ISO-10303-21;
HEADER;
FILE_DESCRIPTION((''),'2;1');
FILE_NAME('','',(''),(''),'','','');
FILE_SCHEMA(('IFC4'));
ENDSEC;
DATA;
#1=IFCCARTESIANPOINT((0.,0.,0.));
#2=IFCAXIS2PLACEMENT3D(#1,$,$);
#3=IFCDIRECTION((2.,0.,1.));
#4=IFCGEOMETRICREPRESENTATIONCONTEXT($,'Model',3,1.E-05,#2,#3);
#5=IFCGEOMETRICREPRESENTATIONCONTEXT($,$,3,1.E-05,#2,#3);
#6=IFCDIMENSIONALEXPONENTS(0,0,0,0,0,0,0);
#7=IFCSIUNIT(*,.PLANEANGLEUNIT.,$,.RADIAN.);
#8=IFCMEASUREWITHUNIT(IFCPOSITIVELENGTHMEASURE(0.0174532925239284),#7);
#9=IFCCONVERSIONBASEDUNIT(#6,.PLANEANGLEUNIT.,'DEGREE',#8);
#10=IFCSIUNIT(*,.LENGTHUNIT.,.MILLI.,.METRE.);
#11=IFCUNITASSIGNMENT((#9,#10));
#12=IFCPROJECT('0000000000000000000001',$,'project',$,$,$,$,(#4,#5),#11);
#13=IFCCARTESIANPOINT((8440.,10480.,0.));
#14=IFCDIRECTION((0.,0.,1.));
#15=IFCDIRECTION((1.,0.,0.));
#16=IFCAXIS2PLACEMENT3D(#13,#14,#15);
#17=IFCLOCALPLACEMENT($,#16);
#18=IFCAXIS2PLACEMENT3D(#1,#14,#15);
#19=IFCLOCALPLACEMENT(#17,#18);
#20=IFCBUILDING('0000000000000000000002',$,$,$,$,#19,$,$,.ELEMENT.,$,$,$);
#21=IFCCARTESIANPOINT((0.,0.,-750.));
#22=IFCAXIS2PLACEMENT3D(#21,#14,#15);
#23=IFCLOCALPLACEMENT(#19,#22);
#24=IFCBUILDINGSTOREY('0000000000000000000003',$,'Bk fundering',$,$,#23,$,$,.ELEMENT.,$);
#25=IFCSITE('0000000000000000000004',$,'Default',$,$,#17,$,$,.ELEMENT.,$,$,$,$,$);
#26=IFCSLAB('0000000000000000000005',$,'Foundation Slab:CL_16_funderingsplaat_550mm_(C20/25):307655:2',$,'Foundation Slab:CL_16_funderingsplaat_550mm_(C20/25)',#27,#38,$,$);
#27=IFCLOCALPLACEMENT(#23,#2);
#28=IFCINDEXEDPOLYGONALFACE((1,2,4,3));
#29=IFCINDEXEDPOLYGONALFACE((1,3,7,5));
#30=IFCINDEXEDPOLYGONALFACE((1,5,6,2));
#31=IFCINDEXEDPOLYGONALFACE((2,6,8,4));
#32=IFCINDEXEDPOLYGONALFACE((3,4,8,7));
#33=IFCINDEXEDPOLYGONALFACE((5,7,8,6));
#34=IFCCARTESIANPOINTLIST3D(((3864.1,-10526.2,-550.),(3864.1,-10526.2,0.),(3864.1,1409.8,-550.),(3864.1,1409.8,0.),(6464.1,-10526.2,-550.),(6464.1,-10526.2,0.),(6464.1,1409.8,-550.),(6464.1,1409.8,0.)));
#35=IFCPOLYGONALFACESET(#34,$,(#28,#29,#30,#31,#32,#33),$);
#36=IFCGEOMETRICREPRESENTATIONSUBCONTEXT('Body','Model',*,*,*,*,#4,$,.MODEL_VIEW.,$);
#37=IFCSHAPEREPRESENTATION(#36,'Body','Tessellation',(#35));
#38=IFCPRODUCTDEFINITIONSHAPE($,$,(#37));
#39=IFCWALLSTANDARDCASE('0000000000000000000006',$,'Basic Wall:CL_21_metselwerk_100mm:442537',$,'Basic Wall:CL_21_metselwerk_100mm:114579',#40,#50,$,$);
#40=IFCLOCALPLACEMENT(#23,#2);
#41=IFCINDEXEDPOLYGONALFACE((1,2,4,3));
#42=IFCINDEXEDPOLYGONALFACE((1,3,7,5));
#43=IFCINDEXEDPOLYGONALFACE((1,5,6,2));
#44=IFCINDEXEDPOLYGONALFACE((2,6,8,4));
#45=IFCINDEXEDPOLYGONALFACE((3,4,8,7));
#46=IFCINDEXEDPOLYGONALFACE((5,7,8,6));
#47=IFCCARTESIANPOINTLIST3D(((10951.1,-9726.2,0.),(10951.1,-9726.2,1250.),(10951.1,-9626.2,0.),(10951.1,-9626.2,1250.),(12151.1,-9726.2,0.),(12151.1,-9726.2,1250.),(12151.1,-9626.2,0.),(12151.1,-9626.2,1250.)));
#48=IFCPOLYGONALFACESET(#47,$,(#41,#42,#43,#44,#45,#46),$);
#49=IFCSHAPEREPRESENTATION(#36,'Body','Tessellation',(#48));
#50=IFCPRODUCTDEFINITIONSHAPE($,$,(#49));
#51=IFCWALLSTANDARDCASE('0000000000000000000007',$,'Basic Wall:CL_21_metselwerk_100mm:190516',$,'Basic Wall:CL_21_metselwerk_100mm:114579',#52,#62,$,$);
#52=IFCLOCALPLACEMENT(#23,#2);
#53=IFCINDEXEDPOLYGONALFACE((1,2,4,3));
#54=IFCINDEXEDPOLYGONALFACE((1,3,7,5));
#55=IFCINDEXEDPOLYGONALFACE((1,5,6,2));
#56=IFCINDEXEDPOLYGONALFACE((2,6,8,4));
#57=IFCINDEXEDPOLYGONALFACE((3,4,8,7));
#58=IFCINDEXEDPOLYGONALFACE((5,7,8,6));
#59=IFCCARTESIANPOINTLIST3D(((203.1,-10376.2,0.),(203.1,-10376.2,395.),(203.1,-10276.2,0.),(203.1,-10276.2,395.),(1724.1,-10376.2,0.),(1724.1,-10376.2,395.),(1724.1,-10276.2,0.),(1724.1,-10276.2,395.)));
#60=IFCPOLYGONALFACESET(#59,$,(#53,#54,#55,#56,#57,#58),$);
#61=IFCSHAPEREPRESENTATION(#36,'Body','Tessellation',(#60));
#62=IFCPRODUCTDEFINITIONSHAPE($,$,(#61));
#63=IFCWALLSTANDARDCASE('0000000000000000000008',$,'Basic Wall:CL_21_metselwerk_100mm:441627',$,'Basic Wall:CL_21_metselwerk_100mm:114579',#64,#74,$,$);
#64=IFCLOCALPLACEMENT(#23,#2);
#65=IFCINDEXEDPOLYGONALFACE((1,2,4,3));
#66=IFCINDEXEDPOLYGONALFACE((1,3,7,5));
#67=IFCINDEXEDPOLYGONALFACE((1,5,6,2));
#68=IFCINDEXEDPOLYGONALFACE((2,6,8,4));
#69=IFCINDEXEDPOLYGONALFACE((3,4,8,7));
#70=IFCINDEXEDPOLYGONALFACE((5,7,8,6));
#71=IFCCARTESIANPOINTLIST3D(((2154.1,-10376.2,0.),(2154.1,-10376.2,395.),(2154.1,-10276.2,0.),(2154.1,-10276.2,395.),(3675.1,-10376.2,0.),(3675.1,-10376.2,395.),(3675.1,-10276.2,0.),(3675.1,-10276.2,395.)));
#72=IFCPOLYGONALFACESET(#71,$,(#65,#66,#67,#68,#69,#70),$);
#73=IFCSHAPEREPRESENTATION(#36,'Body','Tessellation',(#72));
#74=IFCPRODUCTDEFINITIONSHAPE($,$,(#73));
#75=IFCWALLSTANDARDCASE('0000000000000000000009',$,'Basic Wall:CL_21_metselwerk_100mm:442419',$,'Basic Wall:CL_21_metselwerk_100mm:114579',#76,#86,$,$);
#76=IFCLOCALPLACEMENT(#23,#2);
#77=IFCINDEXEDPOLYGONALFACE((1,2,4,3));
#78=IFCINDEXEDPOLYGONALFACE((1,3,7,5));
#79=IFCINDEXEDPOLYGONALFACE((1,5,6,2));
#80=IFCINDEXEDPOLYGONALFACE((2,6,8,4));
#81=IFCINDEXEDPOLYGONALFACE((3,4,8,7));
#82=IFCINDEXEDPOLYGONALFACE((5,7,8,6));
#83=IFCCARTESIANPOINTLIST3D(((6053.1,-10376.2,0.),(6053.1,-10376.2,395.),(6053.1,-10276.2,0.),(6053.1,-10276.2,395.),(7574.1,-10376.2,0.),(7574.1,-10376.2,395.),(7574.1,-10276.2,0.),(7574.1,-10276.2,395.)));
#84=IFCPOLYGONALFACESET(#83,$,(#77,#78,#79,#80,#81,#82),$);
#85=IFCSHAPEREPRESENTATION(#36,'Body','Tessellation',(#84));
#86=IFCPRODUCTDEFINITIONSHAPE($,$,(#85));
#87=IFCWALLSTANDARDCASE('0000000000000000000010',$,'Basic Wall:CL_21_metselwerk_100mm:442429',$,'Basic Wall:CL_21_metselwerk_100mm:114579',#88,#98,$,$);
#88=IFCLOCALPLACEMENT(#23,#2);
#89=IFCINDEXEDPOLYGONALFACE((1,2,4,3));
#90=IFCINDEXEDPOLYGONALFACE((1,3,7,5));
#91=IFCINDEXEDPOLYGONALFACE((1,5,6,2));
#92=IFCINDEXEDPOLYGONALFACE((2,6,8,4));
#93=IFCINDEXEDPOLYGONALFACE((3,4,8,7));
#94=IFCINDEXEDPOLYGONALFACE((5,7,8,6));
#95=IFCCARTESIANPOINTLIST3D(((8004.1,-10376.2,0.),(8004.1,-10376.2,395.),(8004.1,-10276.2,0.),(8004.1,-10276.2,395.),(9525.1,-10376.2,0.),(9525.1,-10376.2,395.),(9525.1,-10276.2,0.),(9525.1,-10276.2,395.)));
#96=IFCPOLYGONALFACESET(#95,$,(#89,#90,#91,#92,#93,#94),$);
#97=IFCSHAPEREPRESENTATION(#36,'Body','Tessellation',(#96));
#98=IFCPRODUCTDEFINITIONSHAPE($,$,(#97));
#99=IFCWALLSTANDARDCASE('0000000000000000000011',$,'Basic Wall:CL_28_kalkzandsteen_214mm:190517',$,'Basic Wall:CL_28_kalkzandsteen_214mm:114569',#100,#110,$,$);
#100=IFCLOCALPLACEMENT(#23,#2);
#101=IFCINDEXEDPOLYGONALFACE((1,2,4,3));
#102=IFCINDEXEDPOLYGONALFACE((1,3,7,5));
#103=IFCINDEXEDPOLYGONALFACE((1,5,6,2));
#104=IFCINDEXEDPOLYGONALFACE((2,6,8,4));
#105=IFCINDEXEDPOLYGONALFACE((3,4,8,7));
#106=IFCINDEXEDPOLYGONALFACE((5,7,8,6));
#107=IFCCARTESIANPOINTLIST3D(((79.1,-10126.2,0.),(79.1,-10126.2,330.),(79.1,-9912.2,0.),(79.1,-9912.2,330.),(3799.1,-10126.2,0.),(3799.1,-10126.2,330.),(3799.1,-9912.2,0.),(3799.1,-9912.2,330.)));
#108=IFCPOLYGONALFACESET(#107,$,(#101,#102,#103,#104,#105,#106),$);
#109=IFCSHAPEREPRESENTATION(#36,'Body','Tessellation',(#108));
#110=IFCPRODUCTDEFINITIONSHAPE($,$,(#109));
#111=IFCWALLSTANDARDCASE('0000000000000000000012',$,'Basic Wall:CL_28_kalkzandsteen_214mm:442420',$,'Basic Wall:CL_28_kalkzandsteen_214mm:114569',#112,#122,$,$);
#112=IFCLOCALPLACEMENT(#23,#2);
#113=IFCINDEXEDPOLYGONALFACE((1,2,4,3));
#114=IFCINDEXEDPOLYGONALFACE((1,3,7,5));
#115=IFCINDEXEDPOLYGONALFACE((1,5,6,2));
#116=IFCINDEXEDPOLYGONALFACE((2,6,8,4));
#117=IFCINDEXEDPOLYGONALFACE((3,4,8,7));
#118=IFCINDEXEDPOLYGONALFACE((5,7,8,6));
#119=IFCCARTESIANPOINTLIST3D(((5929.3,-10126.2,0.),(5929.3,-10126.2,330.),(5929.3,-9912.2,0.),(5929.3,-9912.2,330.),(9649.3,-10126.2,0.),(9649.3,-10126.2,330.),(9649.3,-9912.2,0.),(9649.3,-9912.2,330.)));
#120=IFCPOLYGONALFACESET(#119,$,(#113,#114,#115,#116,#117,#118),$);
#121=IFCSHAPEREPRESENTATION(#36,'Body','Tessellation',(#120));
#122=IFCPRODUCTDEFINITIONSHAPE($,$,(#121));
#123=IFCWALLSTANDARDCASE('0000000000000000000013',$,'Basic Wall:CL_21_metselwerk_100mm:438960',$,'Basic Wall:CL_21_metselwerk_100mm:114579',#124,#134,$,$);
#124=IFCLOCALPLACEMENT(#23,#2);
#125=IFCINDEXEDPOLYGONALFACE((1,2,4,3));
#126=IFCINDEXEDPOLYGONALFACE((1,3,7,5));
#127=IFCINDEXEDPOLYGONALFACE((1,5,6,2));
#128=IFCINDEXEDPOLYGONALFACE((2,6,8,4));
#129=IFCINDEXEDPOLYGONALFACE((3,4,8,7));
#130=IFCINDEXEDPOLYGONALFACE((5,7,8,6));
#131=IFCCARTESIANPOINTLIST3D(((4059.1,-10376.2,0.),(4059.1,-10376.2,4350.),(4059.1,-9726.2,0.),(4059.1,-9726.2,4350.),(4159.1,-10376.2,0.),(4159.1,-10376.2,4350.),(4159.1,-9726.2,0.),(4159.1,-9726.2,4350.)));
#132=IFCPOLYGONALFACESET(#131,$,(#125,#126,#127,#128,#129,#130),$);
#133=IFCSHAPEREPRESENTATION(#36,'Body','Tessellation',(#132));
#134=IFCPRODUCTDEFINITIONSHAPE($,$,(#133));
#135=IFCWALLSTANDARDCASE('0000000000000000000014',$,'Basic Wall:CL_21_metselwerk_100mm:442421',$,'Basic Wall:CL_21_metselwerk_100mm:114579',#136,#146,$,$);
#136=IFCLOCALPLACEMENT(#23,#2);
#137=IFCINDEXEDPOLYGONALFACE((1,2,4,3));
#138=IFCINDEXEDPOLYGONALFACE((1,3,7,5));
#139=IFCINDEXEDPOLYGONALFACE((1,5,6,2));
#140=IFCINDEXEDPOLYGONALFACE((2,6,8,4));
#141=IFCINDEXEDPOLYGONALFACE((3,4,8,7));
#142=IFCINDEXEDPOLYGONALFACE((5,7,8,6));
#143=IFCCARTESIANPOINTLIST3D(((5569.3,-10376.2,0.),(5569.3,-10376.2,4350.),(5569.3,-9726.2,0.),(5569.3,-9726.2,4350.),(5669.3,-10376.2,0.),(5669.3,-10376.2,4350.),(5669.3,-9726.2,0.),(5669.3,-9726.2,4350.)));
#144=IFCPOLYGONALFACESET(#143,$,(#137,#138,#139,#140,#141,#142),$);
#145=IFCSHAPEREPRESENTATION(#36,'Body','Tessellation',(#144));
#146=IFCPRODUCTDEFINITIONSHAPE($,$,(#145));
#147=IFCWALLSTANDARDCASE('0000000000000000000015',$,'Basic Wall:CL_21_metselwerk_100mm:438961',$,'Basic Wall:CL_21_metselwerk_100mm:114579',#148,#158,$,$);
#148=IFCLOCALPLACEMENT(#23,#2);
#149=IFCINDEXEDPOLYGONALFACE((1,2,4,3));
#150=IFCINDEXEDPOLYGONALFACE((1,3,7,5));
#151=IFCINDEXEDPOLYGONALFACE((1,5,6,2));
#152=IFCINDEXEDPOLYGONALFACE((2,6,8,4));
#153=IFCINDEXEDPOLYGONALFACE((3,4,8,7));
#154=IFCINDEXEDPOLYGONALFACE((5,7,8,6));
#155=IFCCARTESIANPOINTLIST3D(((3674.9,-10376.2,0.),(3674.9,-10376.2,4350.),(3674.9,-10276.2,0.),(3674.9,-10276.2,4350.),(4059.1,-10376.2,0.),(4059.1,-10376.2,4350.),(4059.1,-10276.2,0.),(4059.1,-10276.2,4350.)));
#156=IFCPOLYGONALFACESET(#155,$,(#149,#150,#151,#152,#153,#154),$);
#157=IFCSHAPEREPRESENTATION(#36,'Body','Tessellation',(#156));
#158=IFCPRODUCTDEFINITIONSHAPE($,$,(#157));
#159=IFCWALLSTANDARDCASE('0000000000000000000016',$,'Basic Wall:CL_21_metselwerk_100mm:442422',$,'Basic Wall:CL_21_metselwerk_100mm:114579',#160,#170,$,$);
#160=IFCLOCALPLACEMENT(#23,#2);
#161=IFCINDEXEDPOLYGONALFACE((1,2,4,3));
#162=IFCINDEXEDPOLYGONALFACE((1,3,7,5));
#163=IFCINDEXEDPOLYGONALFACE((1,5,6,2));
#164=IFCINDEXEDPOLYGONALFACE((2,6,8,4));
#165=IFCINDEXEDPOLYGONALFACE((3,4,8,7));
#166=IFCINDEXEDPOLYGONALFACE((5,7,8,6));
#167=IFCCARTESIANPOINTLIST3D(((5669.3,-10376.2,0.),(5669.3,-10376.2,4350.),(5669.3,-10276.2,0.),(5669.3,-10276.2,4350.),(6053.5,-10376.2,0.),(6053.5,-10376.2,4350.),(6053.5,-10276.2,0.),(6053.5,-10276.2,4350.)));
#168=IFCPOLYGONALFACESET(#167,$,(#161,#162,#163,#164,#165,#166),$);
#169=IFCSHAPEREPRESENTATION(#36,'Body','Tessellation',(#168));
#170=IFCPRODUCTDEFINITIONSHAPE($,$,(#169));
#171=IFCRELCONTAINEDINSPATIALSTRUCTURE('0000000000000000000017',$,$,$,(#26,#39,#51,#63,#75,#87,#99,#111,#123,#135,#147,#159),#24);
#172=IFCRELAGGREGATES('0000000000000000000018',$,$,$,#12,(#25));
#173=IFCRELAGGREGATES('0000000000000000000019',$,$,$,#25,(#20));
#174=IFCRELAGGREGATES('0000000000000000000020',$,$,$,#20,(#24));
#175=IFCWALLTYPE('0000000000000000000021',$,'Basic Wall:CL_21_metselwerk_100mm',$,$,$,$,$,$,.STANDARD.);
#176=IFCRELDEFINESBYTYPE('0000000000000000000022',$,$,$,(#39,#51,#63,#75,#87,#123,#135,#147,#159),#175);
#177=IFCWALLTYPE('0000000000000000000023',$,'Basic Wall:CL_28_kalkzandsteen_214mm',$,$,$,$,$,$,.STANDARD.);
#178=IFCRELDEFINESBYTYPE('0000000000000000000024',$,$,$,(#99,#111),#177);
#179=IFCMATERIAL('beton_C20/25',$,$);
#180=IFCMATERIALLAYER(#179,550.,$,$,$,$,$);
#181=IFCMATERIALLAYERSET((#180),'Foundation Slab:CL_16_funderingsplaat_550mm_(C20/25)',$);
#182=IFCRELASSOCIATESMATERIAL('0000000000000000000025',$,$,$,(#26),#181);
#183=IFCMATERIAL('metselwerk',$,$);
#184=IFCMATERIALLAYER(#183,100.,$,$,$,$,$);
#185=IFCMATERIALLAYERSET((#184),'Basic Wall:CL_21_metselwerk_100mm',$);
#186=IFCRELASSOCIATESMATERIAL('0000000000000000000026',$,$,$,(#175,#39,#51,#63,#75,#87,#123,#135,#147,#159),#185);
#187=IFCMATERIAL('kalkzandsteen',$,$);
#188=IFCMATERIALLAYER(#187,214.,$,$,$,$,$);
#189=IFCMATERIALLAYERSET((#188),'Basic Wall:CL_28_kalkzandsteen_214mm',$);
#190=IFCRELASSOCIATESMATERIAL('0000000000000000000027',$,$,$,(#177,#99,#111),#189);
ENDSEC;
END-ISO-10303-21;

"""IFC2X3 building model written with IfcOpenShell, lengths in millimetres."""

from ifc_helpers import new_model, entity, si_unit, converted_unit, direction, frame, frame_2d, origin, origin_with_axes, place, context, subcontext, project, spatial, rectangle, extrude, source, transform, mapped, material, layer, layer_set, layer_usage, type_object, element, save


model = new_model("IFC2X3")

# Units and contexts
model_context = context("Model", 3, precision=1e-05, world=origin(), true_north=direction((2.0, 0.0, 1.0)))
context_of_model = context(None, 3, precision=1e-05, world=origin(), true_north=direction((2.0, 0.0, 1.0)))
body_context = subcontext(model_context, "Body", "Model", "MODEL_VIEW")
ifc_project = project(units=[converted_unit("PLANEANGLEUNIT", "DEGREE", entity("IfcPositiveLengthMeasure", 0.0174532925239284), si_unit("PLANEANGLEUNIT", "RADIAN"), dimensions=[0, 0, 0, 0, 0, 0, 0]), si_unit("LENGTHUNIT", "METRE", prefix="MILLI")], contexts=[model_context, context_of_model])

# Site, building, storey
site_placement = place(None, frame((8440.0, 10480.0, 0.0), z_axis=(0.0, 0.0, 1.0), x_axis=(1.0, 0.0, 0.0)))
site = spatial("IfcSite", under=ifc_project, at=site_placement, Name="Default", CompositionType="ELEMENT")
building_placement = place(site_placement, origin_with_axes())
building = spatial("IfcBuilding", under=site, at=building_placement, CompositionType="ELEMENT")
storey_placement = place(building_placement, frame((0.0, 0.0, -750.0), z_axis=(0.0, 0.0, 1.0), x_axis=(1.0, 0.0, 0.0)))
storey = spatial("IfcBuildingStorey", under=building, at=storey_placement, Name="Bk fundering", CompositionType="ELEMENT")

# Slab
ifc_material_1 = material(Name="beton_C20/25")
ifc_layer_1 = layer(ifc_material_1, 550.0)
ifc_layer_set_1 = layer_set([ifc_layer_1], Name="Foundation Slab:CL_16_funderingsplaat_550mm_(C20/25)")
ifc_layer_usage_1 = layer_usage(ifc_layer_set_1, "AXIS3", "POSITIVE", 0.0)
slab_1_placement = place(storey_placement, frame((3864.1, -10526.2, -550.0), z_axis=(0.0, 0.0, 1.0), x_axis=(1.0, 0.0, 0.0)))
element("IfcSlab", 1, at=slab_1_placement, inside=storey, material=ifc_layer_usage_1, Name="Foundation Slab:CL_16_funderingsplaat_550mm_(C20/25):307655:2", ObjectType="Foundation Slab:CL_16_funderingsplaat_550mm_(C20/25)", context=body_context, shape_type="SweptSolid", body=[
    extrude(rectangle(XDim=2600.0, YDim=11936.0, at=frame_2d((0.0, -2075.0), x_axis=(1.0, 0.0))), frame((1300.0, 8043.0, 550.0), z_axis=(0.0, 0.0, -1.0), x_axis=(-1.0, 0.0, 0.0)), (0.0, 0.0, 1.0), 550.0),
])

# Walls
ifc_material_2 = material(Name="metselwerk")
ifc_layer_2 = layer(ifc_material_2, 100.0)
ifc_layer_set_2 = layer_set([ifc_layer_2], Name="Basic Wall:CL_21_metselwerk_100mm")
ifc_layer_usage_2 = layer_usage(ifc_layer_set_2, "AXIS2", "NEGATIVE", 50.0)
wall_type_1 = type_object("IfcWallType", Name="Basic Wall:CL_21_metselwerk_100mm", PredefinedType="STANDARD", material=ifc_layer_set_2)
shared_shape_1 = source(origin(), body_context, "Body", "SweptSolid", [
    extrude(rectangle(XDim=1200.0, YDim=100.0, at=frame_2d((600.0, 0.0), x_axis=(-1.0, 0.0))), origin(), (0.0, 0.0, 1.0), 1250.0),
])
wall_1_placement = place(storey_placement, frame((10951.1, -9676.2, 0.0), z_axis=(0.0, 0.0, 1.0), x_axis=(1.0, 0.0, 0.0)))
element("IfcWallStandardCase", 2, at=wall_1_placement, inside=storey, type_object=wall_type_1, material=ifc_layer_usage_2, Name="Basic Wall:CL_21_metselwerk_100mm:442537", ObjectType="Basic Wall:CL_21_metselwerk_100mm:114579", context=body_context, shape_type="MappedRepresentation", body=[
    mapped(shared_shape_1, transform((0.0, 0.0, 0.0))),
])
ifc_layer_usage_3 = layer_usage(ifc_layer_set_2, "AXIS2", "NEGATIVE", 50.0)
shared_shape_2 = source(origin(), body_context, "Body", "SweptSolid", [
    extrude(rectangle(XDim=1521.0, YDim=100.0, at=frame_2d((760.5, 0.0), x_axis=(-1.0, 0.0))), origin(), (0.0, 0.0, 1.0), 395.0),
])
wall_2_placement = place(storey_placement, frame((203.1, -10326.2, 0.0), z_axis=(0.0, 0.0, 1.0), x_axis=(1.0, 0.0, 0.0)))
element("IfcWallStandardCase", 3, at=wall_2_placement, inside=storey, type_object=wall_type_1, material=ifc_layer_usage_3, Name="Basic Wall:CL_21_metselwerk_100mm:190516", ObjectType="Basic Wall:CL_21_metselwerk_100mm:114579", context=body_context, shape_type="MappedRepresentation", body=[
    mapped(shared_shape_2, transform((0.0, 0.0, 0.0))),
])
ifc_layer_usage_4 = layer_usage(ifc_layer_set_2, "AXIS2", "NEGATIVE", 50.0)
wall_3_placement = place(storey_placement, frame((2154.1, -10326.2, 0.0), z_axis=(0.0, 0.0, 1.0), x_axis=(1.0, 0.0, 0.0)))
element("IfcWallStandardCase", 4, at=wall_3_placement, inside=storey, type_object=wall_type_1, material=ifc_layer_usage_4, Name="Basic Wall:CL_21_metselwerk_100mm:441627", ObjectType="Basic Wall:CL_21_metselwerk_100mm:114579", context=body_context, shape_type="MappedRepresentation", body=[
    mapped(shared_shape_2, transform((0.0, 0.0, 0.0))),
])
ifc_layer_usage_5 = layer_usage(ifc_layer_set_2, "AXIS2", "NEGATIVE", 50.0)
wall_4_placement = place(storey_placement, frame((6053.1, -10326.2, 0.0), z_axis=(0.0, 0.0, 1.0), x_axis=(1.0, 0.0, 0.0)))
element("IfcWallStandardCase", 5, at=wall_4_placement, inside=storey, type_object=wall_type_1, material=ifc_layer_usage_5, Name="Basic Wall:CL_21_metselwerk_100mm:442419", ObjectType="Basic Wall:CL_21_metselwerk_100mm:114579", context=body_context, shape_type="MappedRepresentation", body=[
    mapped(shared_shape_2, transform((0.0, 0.0, 0.0))),
])
ifc_layer_usage_6 = layer_usage(ifc_layer_set_2, "AXIS2", "NEGATIVE", 50.0)
wall_5_placement = place(storey_placement, frame((8004.1, -10326.2, 0.0), z_axis=(0.0, 0.0, 1.0), x_axis=(1.0, 0.0, 0.0)))
element("IfcWallStandardCase", 6, at=wall_5_placement, inside=storey, type_object=wall_type_1, material=ifc_layer_usage_6, Name="Basic Wall:CL_21_metselwerk_100mm:442429", ObjectType="Basic Wall:CL_21_metselwerk_100mm:114579", context=body_context, shape_type="MappedRepresentation", body=[
    mapped(shared_shape_2, transform((0.0, 0.0, 0.0))),
])
ifc_material_3 = material(Name="kalkzandsteen")
ifc_layer_3 = layer(ifc_material_3, 214.0)
ifc_layer_set_3 = layer_set([ifc_layer_3], Name="Basic Wall:CL_28_kalkzandsteen_214mm")
ifc_layer_usage_7 = layer_usage(ifc_layer_set_3, "AXIS2", "NEGATIVE", 107.0)
wall_type_2 = type_object("IfcWallType", Name="Basic Wall:CL_28_kalkzandsteen_214mm", PredefinedType="STANDARD", material=ifc_layer_set_3)
shared_shape_3 = source(origin(), body_context, "Body", "SweptSolid", [
    extrude(rectangle(XDim=3720.0, YDim=214.0, at=frame_2d((1860.0, 0.0), x_axis=(-1.0, 0.0))), origin(), (0.0, 0.0, 1.0), 330.0),
])
wall_6_placement = place(storey_placement, frame((79.1, -10019.2, 0.0), z_axis=(0.0, 0.0, 1.0), x_axis=(1.0, 0.0, 0.0)))
element("IfcWallStandardCase", 7, at=wall_6_placement, inside=storey, type_object=wall_type_2, material=ifc_layer_usage_7, Name="Basic Wall:CL_28_kalkzandsteen_214mm:190517", ObjectType="Basic Wall:CL_28_kalkzandsteen_214mm:114569", context=body_context, shape_type="MappedRepresentation", body=[
    mapped(shared_shape_3, transform((0.0, 0.0, 0.0))),
])
ifc_layer_usage_8 = layer_usage(ifc_layer_set_3, "AXIS2", "NEGATIVE", 107.0)
wall_7_placement = place(storey_placement, frame((5929.3, -10019.2, 0.0), z_axis=(0.0, 0.0, 1.0), x_axis=(1.0, 0.0, 0.0)))
element("IfcWallStandardCase", 8, at=wall_7_placement, inside=storey, type_object=wall_type_2, material=ifc_layer_usage_8, Name="Basic Wall:CL_28_kalkzandsteen_214mm:442420", ObjectType="Basic Wall:CL_28_kalkzandsteen_214mm:114569", context=body_context, shape_type="MappedRepresentation", body=[
    mapped(shared_shape_3, transform((0.0, 0.0, 0.0))),
])
ifc_layer_usage_9 = layer_usage(ifc_layer_set_2, "AXIS2", "POSITIVE", -50.0)
shared_shape_4 = source(origin(), body_context, "Body", "SweptSolid", [
    extrude(rectangle(XDim=650.0, YDim=100.0, at=frame_2d((325.0, 0.0), x_axis=(-1.0, 0.0))), origin(), (0.0, 0.0, 1.0), 4350.0),
])
wall_8_placement = place(storey_placement, frame((4109.1, -9726.2, 0.0), z_axis=(0.0, 0.0, 1.0), x_axis=(0.0, -1.0, 0.0)))
element("IfcWallStandardCase", 9, at=wall_8_placement, inside=storey, type_object=wall_type_1, material=ifc_layer_usage_9, Name="Basic Wall:CL_21_metselwerk_100mm:438960", ObjectType="Basic Wall:CL_21_metselwerk_100mm:114579", context=body_context, shape_type="MappedRepresentation", body=[
    mapped(shared_shape_4, transform((0.0, 0.0, 0.0))),
])
ifc_layer_usage_10 = layer_usage(ifc_layer_set_2, "AXIS2", "NEGATIVE", 50.0)
wall_9_placement = place(storey_placement, frame((5619.3, -9726.2, 0.0), z_axis=(0.0, 0.0, 1.0), x_axis=(0.0, -1.0, 0.0)))
element("IfcWallStandardCase", 10, at=wall_9_placement, inside=storey, type_object=wall_type_1, material=ifc_layer_usage_10, Name="Basic Wall:CL_21_metselwerk_100mm:442421", ObjectType="Basic Wall:CL_21_metselwerk_100mm:114579", context=body_context, shape_type="MappedRepresentation", body=[
    mapped(shared_shape_4, transform((0.0, 0.0, 0.0))),
])
ifc_layer_usage_11 = layer_usage(ifc_layer_set_2, "AXIS2", "POSITIVE", -50.0)
shared_shape_5 = source(origin(), body_context, "Body", "SweptSolid", [
    extrude(rectangle(XDim=384.2, YDim=100.0, at=frame_2d((192.1, 0.0), x_axis=(-1.0, 0.0))), origin(), (0.0, 0.0, 1.0), 4350.0),
])
wall_10_placement = place(storey_placement, frame((4059.1, -10326.2, 0.0), z_axis=(0.0, 0.0, 1.0), x_axis=(-1.0, 0.0, 0.0)))
element("IfcWallStandardCase", 11, at=wall_10_placement, inside=storey, type_object=wall_type_1, material=ifc_layer_usage_11, Name="Basic Wall:CL_21_metselwerk_100mm:438961", ObjectType="Basic Wall:CL_21_metselwerk_100mm:114579", context=body_context, shape_type="MappedRepresentation", body=[
    mapped(shared_shape_5, transform((0.0, 0.0, 0.0))),
])
ifc_layer_usage_12 = layer_usage(ifc_layer_set_2, "AXIS2", "NEGATIVE", 50.0)
wall_11_placement = place(storey_placement, frame((5669.3, -10326.2, 0.0), z_axis=(0.0, 0.0, 1.0), x_axis=(1.0, 0.0, 0.0)))
element("IfcWallStandardCase", 12, at=wall_11_placement, inside=storey, type_object=wall_type_1, material=ifc_layer_usage_12, Name="Basic Wall:CL_21_metselwerk_100mm:442422", ObjectType="Basic Wall:CL_21_metselwerk_100mm:114579", context=body_context, shape_type="MappedRepresentation", body=[
    mapped(shared_shape_5, transform((0.0, 0.0, 0.0))),
])

save(model, "model.ifc")
